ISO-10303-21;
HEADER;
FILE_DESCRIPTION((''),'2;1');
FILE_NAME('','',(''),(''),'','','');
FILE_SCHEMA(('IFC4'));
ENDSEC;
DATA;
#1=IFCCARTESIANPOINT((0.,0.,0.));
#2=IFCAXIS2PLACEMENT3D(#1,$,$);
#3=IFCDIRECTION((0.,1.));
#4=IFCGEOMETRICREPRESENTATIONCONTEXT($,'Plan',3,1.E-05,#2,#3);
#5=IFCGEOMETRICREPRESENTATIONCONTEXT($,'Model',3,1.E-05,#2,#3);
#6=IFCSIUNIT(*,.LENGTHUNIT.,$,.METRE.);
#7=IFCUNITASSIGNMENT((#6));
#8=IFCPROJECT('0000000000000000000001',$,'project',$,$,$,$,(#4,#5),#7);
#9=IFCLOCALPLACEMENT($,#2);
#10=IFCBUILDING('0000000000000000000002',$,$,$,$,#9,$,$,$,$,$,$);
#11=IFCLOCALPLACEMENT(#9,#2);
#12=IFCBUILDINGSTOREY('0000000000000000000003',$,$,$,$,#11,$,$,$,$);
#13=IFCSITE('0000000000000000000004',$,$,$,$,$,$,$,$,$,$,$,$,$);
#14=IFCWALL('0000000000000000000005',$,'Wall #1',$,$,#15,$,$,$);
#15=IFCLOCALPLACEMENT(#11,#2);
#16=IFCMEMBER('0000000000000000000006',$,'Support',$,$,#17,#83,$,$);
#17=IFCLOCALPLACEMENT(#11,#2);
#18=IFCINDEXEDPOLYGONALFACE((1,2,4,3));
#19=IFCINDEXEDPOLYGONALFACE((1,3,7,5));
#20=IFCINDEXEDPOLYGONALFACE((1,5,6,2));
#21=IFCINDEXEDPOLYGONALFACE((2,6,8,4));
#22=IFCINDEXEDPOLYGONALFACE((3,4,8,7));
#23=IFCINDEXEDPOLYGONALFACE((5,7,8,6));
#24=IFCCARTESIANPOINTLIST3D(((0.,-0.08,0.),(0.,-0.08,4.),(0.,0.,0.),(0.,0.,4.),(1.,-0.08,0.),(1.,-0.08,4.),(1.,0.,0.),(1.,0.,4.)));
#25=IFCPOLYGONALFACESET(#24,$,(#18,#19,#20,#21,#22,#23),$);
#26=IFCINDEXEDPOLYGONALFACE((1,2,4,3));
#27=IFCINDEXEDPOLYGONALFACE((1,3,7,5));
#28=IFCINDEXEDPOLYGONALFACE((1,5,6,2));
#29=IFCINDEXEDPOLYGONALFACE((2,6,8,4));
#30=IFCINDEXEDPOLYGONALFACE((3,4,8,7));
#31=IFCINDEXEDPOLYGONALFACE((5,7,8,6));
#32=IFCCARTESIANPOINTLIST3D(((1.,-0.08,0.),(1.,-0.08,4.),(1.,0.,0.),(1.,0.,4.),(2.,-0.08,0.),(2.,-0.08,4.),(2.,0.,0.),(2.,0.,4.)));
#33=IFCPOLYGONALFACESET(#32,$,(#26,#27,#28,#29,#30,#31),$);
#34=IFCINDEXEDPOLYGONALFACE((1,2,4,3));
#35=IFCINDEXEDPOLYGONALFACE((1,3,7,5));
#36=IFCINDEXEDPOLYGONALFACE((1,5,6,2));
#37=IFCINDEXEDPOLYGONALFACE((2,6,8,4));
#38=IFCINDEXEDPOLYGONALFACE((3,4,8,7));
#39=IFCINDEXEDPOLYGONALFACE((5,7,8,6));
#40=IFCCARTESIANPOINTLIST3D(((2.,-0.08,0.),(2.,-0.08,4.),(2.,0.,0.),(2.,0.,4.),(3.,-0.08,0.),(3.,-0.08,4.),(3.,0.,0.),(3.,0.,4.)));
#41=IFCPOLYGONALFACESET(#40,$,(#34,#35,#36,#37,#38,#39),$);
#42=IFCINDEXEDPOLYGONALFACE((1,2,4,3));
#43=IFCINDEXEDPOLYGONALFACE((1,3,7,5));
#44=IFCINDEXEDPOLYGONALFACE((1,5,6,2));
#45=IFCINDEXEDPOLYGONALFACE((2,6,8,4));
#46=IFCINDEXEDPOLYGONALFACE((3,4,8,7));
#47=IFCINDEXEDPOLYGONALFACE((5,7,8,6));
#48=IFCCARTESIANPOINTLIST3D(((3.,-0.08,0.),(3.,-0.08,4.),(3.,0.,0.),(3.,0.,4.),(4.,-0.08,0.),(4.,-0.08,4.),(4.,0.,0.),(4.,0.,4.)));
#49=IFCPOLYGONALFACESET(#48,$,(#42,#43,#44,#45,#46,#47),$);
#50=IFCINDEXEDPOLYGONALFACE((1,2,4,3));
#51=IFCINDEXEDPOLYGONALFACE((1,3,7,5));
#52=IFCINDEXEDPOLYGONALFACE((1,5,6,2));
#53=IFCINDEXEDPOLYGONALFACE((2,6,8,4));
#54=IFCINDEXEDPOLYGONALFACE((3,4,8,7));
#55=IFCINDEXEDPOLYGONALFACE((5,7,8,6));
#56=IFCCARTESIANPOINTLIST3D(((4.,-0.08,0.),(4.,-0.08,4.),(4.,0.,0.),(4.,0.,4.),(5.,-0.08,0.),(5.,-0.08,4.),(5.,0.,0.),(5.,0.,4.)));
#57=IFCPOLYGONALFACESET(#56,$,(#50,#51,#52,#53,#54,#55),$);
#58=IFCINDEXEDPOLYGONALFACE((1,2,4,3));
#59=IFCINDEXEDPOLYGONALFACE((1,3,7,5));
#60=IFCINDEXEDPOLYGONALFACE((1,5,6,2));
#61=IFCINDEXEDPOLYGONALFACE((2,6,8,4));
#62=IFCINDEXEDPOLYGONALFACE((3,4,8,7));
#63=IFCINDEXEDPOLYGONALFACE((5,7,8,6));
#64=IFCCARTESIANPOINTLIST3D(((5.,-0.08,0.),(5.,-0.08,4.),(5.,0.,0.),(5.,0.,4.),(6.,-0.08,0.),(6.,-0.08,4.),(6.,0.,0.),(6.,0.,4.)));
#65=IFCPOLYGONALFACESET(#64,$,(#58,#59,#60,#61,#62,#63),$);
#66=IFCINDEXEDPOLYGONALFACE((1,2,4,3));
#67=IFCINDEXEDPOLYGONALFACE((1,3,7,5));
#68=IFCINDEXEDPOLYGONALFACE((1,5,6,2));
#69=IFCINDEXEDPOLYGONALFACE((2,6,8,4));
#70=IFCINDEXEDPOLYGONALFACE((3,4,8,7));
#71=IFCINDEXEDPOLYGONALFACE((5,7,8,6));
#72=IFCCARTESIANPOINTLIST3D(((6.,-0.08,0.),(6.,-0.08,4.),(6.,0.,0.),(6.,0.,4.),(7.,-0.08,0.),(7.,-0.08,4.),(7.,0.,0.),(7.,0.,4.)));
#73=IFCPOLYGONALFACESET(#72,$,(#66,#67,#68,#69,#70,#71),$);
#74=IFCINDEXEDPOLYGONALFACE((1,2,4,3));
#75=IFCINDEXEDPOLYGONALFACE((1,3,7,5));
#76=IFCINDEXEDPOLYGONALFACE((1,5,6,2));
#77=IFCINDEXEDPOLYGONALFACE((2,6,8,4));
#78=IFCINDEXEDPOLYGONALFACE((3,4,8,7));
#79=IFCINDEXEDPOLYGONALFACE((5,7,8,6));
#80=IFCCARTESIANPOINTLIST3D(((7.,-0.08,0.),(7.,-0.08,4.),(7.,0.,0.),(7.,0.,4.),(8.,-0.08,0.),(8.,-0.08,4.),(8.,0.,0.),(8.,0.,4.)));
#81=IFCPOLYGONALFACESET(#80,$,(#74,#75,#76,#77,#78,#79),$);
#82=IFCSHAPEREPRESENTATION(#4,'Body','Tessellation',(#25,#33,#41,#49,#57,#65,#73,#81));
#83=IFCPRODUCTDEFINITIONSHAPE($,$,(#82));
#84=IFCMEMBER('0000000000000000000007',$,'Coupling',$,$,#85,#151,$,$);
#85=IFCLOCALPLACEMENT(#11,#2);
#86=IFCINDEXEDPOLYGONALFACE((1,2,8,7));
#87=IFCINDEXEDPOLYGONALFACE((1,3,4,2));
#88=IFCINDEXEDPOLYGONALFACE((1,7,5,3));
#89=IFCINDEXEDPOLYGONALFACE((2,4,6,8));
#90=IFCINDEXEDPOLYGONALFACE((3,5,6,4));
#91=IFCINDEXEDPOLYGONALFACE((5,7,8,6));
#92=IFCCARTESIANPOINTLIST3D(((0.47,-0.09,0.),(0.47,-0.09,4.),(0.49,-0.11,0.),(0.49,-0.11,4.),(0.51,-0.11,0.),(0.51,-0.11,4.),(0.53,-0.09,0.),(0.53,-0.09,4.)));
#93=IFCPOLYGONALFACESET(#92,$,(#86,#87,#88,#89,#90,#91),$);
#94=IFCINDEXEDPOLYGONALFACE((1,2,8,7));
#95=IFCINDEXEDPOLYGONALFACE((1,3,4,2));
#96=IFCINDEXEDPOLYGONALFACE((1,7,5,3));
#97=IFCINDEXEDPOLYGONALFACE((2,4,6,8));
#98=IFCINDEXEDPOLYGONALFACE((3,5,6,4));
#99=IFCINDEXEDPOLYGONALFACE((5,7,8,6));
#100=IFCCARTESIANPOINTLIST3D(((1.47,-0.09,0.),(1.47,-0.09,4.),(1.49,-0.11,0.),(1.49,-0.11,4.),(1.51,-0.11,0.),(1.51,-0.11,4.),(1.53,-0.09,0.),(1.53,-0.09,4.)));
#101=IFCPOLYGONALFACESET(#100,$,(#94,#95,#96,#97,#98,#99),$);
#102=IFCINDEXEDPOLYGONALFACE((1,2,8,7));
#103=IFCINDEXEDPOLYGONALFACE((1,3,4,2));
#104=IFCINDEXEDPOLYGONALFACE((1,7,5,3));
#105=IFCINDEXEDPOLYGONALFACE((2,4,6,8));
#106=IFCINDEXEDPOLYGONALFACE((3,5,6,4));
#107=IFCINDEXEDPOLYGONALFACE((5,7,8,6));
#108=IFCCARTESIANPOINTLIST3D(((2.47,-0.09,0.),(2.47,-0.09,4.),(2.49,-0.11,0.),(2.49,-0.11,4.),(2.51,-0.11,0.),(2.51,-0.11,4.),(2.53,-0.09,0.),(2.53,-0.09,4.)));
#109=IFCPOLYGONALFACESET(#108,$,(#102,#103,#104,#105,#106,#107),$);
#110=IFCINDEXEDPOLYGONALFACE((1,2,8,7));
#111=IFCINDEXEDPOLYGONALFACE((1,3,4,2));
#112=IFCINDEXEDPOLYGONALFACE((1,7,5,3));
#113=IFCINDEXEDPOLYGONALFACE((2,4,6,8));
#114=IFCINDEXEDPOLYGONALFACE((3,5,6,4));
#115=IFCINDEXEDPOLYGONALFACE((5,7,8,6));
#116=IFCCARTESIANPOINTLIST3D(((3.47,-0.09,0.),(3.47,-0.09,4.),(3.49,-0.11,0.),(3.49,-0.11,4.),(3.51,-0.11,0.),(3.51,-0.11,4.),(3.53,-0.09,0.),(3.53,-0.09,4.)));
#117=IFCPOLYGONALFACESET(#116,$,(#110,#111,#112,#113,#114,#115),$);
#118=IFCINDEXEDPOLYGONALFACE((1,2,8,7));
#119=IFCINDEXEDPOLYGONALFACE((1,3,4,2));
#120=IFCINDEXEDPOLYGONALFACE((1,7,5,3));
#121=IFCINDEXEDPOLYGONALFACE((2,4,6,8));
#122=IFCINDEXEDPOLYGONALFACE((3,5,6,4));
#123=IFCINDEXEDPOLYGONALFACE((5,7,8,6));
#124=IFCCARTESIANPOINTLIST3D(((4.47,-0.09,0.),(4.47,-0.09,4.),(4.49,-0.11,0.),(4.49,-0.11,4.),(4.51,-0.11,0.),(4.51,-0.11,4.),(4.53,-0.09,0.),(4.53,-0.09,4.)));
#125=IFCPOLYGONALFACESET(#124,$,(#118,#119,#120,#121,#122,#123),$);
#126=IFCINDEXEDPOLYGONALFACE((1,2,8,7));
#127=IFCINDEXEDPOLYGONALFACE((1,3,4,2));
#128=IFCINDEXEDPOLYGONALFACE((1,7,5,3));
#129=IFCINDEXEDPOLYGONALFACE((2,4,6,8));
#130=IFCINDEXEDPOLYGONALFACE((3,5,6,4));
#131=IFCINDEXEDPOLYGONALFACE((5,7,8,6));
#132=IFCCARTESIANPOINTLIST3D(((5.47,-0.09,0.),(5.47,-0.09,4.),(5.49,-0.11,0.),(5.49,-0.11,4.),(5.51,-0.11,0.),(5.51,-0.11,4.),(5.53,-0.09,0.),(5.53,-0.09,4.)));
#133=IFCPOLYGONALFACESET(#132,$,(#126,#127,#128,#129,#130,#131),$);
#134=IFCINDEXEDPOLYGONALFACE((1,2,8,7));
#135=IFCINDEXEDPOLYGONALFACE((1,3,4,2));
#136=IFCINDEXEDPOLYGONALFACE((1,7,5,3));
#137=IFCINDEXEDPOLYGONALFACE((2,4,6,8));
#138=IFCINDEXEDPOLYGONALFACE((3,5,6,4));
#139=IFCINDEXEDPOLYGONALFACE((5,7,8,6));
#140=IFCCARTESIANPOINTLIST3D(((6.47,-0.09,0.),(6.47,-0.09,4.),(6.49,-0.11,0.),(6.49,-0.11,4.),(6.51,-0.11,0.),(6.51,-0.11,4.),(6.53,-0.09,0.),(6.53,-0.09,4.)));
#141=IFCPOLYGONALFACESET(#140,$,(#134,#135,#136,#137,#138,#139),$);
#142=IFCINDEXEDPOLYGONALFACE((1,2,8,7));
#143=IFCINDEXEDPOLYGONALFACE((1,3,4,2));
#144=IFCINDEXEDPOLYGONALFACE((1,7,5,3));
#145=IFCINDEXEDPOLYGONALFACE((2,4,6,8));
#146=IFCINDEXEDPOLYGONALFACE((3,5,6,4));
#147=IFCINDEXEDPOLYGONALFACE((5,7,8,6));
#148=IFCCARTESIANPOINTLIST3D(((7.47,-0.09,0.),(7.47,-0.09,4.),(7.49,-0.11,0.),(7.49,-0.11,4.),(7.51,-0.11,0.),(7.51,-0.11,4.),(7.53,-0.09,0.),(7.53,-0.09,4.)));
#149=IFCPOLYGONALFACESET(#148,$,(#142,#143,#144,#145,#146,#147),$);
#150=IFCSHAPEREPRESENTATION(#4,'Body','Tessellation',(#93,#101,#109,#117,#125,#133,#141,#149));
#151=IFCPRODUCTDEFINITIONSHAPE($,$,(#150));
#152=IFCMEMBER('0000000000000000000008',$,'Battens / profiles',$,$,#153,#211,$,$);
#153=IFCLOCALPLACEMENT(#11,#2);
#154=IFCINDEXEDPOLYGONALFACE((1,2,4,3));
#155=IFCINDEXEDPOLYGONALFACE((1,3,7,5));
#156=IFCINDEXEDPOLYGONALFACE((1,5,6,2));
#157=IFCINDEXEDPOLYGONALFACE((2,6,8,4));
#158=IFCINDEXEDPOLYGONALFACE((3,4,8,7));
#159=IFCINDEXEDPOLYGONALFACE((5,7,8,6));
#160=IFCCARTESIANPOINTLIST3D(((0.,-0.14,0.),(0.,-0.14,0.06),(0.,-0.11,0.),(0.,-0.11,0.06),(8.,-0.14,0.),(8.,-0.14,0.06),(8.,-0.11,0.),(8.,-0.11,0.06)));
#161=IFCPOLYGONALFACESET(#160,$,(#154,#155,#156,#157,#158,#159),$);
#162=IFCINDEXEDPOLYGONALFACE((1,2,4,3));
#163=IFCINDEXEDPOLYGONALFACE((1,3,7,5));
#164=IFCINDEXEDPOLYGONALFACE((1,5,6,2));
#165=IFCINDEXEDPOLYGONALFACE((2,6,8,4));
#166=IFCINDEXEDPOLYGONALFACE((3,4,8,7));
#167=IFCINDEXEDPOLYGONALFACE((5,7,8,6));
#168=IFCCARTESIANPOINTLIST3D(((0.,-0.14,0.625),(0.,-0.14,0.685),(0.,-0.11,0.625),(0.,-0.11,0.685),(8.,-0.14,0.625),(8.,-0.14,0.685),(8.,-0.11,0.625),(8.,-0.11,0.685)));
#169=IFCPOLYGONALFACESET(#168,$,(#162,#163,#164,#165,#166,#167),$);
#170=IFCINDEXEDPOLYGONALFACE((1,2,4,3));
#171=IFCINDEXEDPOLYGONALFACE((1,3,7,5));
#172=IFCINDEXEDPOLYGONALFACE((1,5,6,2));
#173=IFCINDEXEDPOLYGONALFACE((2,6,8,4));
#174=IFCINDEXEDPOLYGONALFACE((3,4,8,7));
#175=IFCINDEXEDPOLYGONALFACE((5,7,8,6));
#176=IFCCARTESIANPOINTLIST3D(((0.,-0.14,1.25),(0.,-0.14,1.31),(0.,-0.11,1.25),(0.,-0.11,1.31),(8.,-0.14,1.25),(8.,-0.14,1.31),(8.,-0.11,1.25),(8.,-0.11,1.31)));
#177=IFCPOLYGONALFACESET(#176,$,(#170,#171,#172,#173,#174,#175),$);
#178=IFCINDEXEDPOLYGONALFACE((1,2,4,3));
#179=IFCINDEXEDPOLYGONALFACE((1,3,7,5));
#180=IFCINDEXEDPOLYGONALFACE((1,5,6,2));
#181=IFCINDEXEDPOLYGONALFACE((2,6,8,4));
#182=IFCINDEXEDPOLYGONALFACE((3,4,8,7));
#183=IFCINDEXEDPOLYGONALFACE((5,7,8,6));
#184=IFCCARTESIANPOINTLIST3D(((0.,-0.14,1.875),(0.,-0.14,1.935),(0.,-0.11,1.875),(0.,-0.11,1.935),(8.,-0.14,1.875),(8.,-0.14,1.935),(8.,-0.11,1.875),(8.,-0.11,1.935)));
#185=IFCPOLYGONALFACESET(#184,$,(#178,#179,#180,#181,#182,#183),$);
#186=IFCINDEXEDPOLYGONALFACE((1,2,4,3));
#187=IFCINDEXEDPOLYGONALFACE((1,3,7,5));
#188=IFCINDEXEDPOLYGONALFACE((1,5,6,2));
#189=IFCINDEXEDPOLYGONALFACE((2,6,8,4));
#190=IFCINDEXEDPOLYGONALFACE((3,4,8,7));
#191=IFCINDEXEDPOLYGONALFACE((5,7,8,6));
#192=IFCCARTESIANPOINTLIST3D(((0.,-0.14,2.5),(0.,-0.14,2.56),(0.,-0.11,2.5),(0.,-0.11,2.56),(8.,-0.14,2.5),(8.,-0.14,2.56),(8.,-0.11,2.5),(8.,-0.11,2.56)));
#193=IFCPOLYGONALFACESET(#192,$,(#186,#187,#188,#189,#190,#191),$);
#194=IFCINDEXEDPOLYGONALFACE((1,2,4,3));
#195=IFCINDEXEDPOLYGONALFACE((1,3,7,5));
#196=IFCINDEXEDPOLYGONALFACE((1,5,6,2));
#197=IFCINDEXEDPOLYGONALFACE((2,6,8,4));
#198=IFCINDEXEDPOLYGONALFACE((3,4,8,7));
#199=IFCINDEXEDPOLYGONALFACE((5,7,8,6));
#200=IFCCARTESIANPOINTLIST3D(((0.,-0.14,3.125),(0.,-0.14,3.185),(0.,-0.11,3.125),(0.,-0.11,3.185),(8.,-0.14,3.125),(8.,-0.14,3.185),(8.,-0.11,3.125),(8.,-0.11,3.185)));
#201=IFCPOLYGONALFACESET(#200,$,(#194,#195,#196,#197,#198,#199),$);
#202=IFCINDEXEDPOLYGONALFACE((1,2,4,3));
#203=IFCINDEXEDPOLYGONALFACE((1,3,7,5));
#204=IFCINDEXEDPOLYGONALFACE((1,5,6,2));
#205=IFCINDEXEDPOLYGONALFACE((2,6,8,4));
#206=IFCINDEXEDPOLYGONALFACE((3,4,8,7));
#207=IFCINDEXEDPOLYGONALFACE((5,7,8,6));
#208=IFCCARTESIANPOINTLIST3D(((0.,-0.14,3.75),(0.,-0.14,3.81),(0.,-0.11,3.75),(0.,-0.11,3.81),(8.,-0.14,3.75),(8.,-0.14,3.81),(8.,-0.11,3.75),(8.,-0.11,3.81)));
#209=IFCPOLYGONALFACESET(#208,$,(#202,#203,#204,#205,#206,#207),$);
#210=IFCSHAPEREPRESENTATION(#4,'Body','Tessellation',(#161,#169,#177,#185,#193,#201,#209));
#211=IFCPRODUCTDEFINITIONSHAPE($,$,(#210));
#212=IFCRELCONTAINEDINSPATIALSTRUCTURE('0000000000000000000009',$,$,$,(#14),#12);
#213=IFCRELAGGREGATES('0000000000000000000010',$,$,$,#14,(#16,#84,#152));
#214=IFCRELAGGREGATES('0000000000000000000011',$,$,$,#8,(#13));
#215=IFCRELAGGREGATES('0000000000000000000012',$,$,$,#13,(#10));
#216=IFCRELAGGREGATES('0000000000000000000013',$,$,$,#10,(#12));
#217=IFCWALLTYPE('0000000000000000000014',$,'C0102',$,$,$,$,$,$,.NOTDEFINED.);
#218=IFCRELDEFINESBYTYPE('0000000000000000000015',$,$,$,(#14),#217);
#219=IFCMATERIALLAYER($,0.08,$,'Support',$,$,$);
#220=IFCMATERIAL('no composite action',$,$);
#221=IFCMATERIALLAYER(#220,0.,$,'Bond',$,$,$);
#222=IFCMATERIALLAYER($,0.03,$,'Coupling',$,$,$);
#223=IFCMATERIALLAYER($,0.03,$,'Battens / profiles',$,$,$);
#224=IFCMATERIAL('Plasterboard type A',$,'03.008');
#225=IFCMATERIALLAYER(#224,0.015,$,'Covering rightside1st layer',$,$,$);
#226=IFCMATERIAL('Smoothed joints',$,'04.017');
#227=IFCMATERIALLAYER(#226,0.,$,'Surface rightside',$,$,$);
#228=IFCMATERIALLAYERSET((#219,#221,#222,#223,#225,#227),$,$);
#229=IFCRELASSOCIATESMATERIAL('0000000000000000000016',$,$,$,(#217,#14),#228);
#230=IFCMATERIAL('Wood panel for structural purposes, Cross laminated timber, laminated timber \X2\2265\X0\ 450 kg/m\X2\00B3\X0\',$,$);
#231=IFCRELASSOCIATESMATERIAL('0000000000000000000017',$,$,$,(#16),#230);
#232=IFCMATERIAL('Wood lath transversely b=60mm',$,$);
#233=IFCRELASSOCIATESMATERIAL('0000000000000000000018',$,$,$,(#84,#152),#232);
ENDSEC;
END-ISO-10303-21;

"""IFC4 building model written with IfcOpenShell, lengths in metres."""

from ifc_helpers import new_model, si_unit, direction, frame, frame_2d, origin, place, context, project, spatial, polyline, rectangle, outline, extrude, material, layer, layer_set, type_object, element, aggregate, save


model = new_model("IFC4")

# Units and contexts
plan_context = context("Plan", 3, precision=1e-05, world=origin(), true_north=direction((0.0, 1.0)))
model_context = context("Model", 3, precision=1e-05, world=origin(), true_north=direction((0.0, 1.0)))
ifc_project = project(units=[si_unit("LENGTHUNIT", "METRE")], contexts=[plan_context, model_context])

# Site, building, storey
site = spatial("IfcSite", under=ifc_project)
building_placement = place(None, origin())
building = spatial("IfcBuilding", under=site, at=building_placement)
storey_placement = place(building_placement, origin())
storey = spatial("IfcBuildingStorey", under=building, at=storey_placement)

# Wall, members
ifc_layer_1 = layer(None, 0.08, Name="Support")
ifc_material_1 = material(Name="no composite action")
ifc_layer_2 = layer(ifc_material_1, 0.0, Name="Bond")
ifc_layer_3 = layer(None, 0.03, Name="Coupling")
ifc_layer_4 = layer(None, 0.03, Name="Battens / profiles")
ifc_material_2 = material(Name="Plasterboard type A", Category="03.008")
ifc_layer_5 = layer(ifc_material_2, 0.015, Name="Covering rightside1st layer")
ifc_material_3 = material(Name="Smoothed joints", Category="04.017")
ifc_layer_6 = layer(ifc_material_3, 0.0, Name="Surface rightside")
ifc_layer_set = layer_set([ifc_layer_1, ifc_layer_2, ifc_layer_3, ifc_layer_4, ifc_layer_5, ifc_layer_6])
wall_type = type_object("IfcWallType", Name="C0102", PredefinedType="NOTDEFINED", material=ifc_layer_set)
wall_placement = place(None, frame((0.0, 0.0, 0.0), z_axis=(0.0, -1.0, 0.0), x_axis=(1.0, 0.0, 0.0)))
wall = element("IfcWall", 1, at=wall_placement, inside=storey, type_object=wall_type, material=ifc_layer_set, Name="Wall #1")
ifc_material_4 = material(Name="Wood panel for structural purposes, Cross laminated timber, laminated timber ≥ 450 kg/m³")
member_1_placement = place(wall_placement, origin())
member_1 = element("IfcMember", 2, at=member_1_placement, material=ifc_material_4, Name="Support", context=plan_context, shape_type="SweptSolid", body=[
    extrude(rectangle(XDim=1.0, YDim=0.08, at=frame_2d((0.5, 0.04), x_axis=(1.0, 0.0))), frame((0.0, 4.0, 0.0), z_axis=(0.0, -1.0, 0.0), x_axis=(1.0, 0.0, 0.0)), (0.0, 0.0, 1.0), 4.0),
    extrude(rectangle(XDim=1.0, YDim=0.08, at=frame_2d((0.5, 0.04), x_axis=(1.0, 0.0))), frame((1.0, 4.0, 0.0), z_axis=(0.0, -1.0, 0.0), x_axis=(1.0, 0.0, 0.0)), (0.0, 0.0, 1.0), 4.0),
    extrude(rectangle(XDim=1.0, YDim=0.08, at=frame_2d((0.5, 0.04), x_axis=(1.0, 0.0))), frame((2.0, 4.0, 0.0), z_axis=(0.0, -1.0, 0.0), x_axis=(1.0, 0.0, 0.0)), (0.0, 0.0, 1.0), 4.0),
    extrude(rectangle(XDim=1.0, YDim=0.08, at=frame_2d((0.5, 0.04), x_axis=(1.0, 0.0))), frame((3.0, 4.0, 0.0), z_axis=(0.0, -1.0, 0.0), x_axis=(1.0, 0.0, 0.0)), (0.0, 0.0, 1.0), 4.0),
    extrude(rectangle(XDim=1.0, YDim=0.08, at=frame_2d((0.5, 0.04), x_axis=(1.0, 0.0))), frame((4.0, 4.0, 0.0), z_axis=(0.0, -1.0, 0.0), x_axis=(1.0, 0.0, 0.0)), (0.0, 0.0, 1.0), 4.0),
    extrude(rectangle(XDim=1.0, YDim=0.08, at=frame_2d((0.5, 0.04), x_axis=(1.0, 0.0))), frame((5.0, 4.0, 0.0), z_axis=(0.0, -1.0, 0.0), x_axis=(1.0, 0.0, 0.0)), (0.0, 0.0, 1.0), 4.0),
    extrude(rectangle(XDim=1.0, YDim=0.08, at=frame_2d((0.5, 0.04), x_axis=(1.0, 0.0))), frame((6.0, 4.0, 0.0), z_axis=(0.0, -1.0, 0.0), x_axis=(1.0, 0.0, 0.0)), (0.0, 0.0, 1.0), 4.0),
    extrude(rectangle(XDim=1.0, YDim=0.08, at=frame_2d((0.5, 0.04), x_axis=(1.0, 0.0))), frame((7.0, 4.0, 0.0), z_axis=(0.0, -1.0, 0.0), x_axis=(1.0, 0.0, 0.0)), (0.0, 0.0, 1.0), 4.0),
])
ifc_material_5 = material(Name="Wood lath transversely b=60mm")
member_2_placement = place(wall_placement, origin())
member_2 = element("IfcMember", 3, at=member_2_placement, material=ifc_material_5, Name="Coupling", context=plan_context, shape_type="SweptSolid", body=[
    extrude(outline(polyline([(0.0, 0.0), (0.06, 0.0), (0.04, 0.02), (0.02, 0.02), (0.0, 0.0)])), frame((0.47, 4.0, 0.09), z_axis=(0.0, -1.0, 0.0), x_axis=(1.0, 0.0, 0.0)), (0.0, 0.0, 1.0), 4.0),
    extrude(outline(polyline([(0.0, 0.0), (0.06, 0.0), (0.04, 0.02), (0.02, 0.02), (0.0, 0.0)])), frame((1.47, 4.0, 0.09), z_axis=(0.0, -1.0, 0.0), x_axis=(1.0, 0.0, 0.0)), (0.0, 0.0, 1.0), 4.0),
    extrude(outline(polyline([(0.0, 0.0), (0.06, 0.0), (0.04, 0.02), (0.02, 0.02), (0.0, 0.0)])), frame((2.47, 4.0, 0.09), z_axis=(0.0, -1.0, 0.0), x_axis=(1.0, 0.0, 0.0)), (0.0, 0.0, 1.0), 4.0),
    extrude(outline(polyline([(0.0, 0.0), (0.06, 0.0), (0.04, 0.02), (0.02, 0.02), (0.0, 0.0)])), frame((3.47, 4.0, 0.09), z_axis=(0.0, -1.0, 0.0), x_axis=(1.0, 0.0, 0.0)), (0.0, 0.0, 1.0), 4.0),
    extrude(outline(polyline([(0.0, 0.0), (0.06, 0.0), (0.04, 0.02), (0.02, 0.02), (0.0, 0.0)])), frame((4.47, 4.0, 0.09), z_axis=(0.0, -1.0, 0.0), x_axis=(1.0, 0.0, 0.0)), (0.0, 0.0, 1.0), 4.0),
    extrude(outline(polyline([(0.0, 0.0), (0.06, 0.0), (0.04, 0.02), (0.02, 0.02), (0.0, 0.0)])), frame((5.47, 4.0, 0.09), z_axis=(0.0, -1.0, 0.0), x_axis=(1.0, 0.0, 0.0)), (0.0, 0.0, 1.0), 4.0),
    extrude(outline(polyline([(0.0, 0.0), (0.06, 0.0), (0.04, 0.02), (0.02, 0.02), (0.0, 0.0)])), frame((6.47, 4.0, 0.09), z_axis=(0.0, -1.0, 0.0), x_axis=(1.0, 0.0, 0.0)), (0.0, 0.0, 1.0), 4.0),
    extrude(outline(polyline([(0.0, 0.0), (0.06, 0.0), (0.04, 0.02), (0.02, 0.02), (0.0, 0.0)])), frame((7.47, 4.0, 0.09), z_axis=(0.0, -1.0, 0.0), x_axis=(1.0, 0.0, 0.0)), (0.0, 0.0, 1.0), 4.0),
])
member_3_placement = place(wall_placement, origin())
member_3 = element("IfcMember", 4, at=member_3_placement, material=ifc_material_5, Name="Battens / profiles", context=plan_context, shape_type="SweptSolid", body=[
    extrude(rectangle(XDim=0.06, YDim=0.03, at=frame_2d((0.03, 0.015), x_axis=(1.0, 0.0))), frame((0.0, 0.0, 0.11), z_axis=(1.0, 0.0, 0.0), x_axis=(0.0, 1.0, 0.0)), (0.0, 0.0, 1.0), 8.0),
    extrude(rectangle(XDim=0.06, YDim=0.03, at=frame_2d((0.03, 0.015), x_axis=(1.0, 0.0))), frame((0.0, 0.625, 0.11), z_axis=(1.0, 0.0, 0.0), x_axis=(0.0, 1.0, 0.0)), (0.0, 0.0, 1.0), 8.0),
    extrude(rectangle(XDim=0.06, YDim=0.03, at=frame_2d((0.03, 0.015), x_axis=(1.0, 0.0))), frame((0.0, 1.25, 0.11), z_axis=(1.0, 0.0, 0.0), x_axis=(0.0, 1.0, 0.0)), (0.0, 0.0, 1.0), 8.0),
    extrude(rectangle(XDim=0.06, YDim=0.03, at=frame_2d((0.03, 0.015), x_axis=(1.0, 0.0))), frame((0.0, 1.875, 0.11), z_axis=(1.0, 0.0, 0.0), x_axis=(0.0, 1.0, 0.0)), (0.0, 0.0, 1.0), 8.0),
    extrude(rectangle(XDim=0.06, YDim=0.03, at=frame_2d((0.03, 0.015), x_axis=(1.0, 0.0))), frame((0.0, 2.5, 0.11), z_axis=(1.0, 0.0, 0.0), x_axis=(0.0, 1.0, 0.0)), (0.0, 0.0, 1.0), 8.0),
    extrude(rectangle(XDim=0.06, YDim=0.03, at=frame_2d((0.03, 0.015), x_axis=(1.0, 0.0))), frame((0.0, 3.125, 0.11), z_axis=(1.0, 0.0, 0.0), x_axis=(0.0, 1.0, 0.0)), (0.0, 0.0, 1.0), 8.0),
    extrude(rectangle(XDim=0.06, YDim=0.03, at=frame_2d((0.03, 0.015), x_axis=(1.0, 0.0))), frame((0.0, 3.75, 0.11), z_axis=(1.0, 0.0, 0.0), x_axis=(0.0, 1.0, 0.0)), (0.0, 0.0, 1.0), 8.0),
])
aggregate(wall, [member_1, member_2, member_3])

save(model, "model.ifc")
